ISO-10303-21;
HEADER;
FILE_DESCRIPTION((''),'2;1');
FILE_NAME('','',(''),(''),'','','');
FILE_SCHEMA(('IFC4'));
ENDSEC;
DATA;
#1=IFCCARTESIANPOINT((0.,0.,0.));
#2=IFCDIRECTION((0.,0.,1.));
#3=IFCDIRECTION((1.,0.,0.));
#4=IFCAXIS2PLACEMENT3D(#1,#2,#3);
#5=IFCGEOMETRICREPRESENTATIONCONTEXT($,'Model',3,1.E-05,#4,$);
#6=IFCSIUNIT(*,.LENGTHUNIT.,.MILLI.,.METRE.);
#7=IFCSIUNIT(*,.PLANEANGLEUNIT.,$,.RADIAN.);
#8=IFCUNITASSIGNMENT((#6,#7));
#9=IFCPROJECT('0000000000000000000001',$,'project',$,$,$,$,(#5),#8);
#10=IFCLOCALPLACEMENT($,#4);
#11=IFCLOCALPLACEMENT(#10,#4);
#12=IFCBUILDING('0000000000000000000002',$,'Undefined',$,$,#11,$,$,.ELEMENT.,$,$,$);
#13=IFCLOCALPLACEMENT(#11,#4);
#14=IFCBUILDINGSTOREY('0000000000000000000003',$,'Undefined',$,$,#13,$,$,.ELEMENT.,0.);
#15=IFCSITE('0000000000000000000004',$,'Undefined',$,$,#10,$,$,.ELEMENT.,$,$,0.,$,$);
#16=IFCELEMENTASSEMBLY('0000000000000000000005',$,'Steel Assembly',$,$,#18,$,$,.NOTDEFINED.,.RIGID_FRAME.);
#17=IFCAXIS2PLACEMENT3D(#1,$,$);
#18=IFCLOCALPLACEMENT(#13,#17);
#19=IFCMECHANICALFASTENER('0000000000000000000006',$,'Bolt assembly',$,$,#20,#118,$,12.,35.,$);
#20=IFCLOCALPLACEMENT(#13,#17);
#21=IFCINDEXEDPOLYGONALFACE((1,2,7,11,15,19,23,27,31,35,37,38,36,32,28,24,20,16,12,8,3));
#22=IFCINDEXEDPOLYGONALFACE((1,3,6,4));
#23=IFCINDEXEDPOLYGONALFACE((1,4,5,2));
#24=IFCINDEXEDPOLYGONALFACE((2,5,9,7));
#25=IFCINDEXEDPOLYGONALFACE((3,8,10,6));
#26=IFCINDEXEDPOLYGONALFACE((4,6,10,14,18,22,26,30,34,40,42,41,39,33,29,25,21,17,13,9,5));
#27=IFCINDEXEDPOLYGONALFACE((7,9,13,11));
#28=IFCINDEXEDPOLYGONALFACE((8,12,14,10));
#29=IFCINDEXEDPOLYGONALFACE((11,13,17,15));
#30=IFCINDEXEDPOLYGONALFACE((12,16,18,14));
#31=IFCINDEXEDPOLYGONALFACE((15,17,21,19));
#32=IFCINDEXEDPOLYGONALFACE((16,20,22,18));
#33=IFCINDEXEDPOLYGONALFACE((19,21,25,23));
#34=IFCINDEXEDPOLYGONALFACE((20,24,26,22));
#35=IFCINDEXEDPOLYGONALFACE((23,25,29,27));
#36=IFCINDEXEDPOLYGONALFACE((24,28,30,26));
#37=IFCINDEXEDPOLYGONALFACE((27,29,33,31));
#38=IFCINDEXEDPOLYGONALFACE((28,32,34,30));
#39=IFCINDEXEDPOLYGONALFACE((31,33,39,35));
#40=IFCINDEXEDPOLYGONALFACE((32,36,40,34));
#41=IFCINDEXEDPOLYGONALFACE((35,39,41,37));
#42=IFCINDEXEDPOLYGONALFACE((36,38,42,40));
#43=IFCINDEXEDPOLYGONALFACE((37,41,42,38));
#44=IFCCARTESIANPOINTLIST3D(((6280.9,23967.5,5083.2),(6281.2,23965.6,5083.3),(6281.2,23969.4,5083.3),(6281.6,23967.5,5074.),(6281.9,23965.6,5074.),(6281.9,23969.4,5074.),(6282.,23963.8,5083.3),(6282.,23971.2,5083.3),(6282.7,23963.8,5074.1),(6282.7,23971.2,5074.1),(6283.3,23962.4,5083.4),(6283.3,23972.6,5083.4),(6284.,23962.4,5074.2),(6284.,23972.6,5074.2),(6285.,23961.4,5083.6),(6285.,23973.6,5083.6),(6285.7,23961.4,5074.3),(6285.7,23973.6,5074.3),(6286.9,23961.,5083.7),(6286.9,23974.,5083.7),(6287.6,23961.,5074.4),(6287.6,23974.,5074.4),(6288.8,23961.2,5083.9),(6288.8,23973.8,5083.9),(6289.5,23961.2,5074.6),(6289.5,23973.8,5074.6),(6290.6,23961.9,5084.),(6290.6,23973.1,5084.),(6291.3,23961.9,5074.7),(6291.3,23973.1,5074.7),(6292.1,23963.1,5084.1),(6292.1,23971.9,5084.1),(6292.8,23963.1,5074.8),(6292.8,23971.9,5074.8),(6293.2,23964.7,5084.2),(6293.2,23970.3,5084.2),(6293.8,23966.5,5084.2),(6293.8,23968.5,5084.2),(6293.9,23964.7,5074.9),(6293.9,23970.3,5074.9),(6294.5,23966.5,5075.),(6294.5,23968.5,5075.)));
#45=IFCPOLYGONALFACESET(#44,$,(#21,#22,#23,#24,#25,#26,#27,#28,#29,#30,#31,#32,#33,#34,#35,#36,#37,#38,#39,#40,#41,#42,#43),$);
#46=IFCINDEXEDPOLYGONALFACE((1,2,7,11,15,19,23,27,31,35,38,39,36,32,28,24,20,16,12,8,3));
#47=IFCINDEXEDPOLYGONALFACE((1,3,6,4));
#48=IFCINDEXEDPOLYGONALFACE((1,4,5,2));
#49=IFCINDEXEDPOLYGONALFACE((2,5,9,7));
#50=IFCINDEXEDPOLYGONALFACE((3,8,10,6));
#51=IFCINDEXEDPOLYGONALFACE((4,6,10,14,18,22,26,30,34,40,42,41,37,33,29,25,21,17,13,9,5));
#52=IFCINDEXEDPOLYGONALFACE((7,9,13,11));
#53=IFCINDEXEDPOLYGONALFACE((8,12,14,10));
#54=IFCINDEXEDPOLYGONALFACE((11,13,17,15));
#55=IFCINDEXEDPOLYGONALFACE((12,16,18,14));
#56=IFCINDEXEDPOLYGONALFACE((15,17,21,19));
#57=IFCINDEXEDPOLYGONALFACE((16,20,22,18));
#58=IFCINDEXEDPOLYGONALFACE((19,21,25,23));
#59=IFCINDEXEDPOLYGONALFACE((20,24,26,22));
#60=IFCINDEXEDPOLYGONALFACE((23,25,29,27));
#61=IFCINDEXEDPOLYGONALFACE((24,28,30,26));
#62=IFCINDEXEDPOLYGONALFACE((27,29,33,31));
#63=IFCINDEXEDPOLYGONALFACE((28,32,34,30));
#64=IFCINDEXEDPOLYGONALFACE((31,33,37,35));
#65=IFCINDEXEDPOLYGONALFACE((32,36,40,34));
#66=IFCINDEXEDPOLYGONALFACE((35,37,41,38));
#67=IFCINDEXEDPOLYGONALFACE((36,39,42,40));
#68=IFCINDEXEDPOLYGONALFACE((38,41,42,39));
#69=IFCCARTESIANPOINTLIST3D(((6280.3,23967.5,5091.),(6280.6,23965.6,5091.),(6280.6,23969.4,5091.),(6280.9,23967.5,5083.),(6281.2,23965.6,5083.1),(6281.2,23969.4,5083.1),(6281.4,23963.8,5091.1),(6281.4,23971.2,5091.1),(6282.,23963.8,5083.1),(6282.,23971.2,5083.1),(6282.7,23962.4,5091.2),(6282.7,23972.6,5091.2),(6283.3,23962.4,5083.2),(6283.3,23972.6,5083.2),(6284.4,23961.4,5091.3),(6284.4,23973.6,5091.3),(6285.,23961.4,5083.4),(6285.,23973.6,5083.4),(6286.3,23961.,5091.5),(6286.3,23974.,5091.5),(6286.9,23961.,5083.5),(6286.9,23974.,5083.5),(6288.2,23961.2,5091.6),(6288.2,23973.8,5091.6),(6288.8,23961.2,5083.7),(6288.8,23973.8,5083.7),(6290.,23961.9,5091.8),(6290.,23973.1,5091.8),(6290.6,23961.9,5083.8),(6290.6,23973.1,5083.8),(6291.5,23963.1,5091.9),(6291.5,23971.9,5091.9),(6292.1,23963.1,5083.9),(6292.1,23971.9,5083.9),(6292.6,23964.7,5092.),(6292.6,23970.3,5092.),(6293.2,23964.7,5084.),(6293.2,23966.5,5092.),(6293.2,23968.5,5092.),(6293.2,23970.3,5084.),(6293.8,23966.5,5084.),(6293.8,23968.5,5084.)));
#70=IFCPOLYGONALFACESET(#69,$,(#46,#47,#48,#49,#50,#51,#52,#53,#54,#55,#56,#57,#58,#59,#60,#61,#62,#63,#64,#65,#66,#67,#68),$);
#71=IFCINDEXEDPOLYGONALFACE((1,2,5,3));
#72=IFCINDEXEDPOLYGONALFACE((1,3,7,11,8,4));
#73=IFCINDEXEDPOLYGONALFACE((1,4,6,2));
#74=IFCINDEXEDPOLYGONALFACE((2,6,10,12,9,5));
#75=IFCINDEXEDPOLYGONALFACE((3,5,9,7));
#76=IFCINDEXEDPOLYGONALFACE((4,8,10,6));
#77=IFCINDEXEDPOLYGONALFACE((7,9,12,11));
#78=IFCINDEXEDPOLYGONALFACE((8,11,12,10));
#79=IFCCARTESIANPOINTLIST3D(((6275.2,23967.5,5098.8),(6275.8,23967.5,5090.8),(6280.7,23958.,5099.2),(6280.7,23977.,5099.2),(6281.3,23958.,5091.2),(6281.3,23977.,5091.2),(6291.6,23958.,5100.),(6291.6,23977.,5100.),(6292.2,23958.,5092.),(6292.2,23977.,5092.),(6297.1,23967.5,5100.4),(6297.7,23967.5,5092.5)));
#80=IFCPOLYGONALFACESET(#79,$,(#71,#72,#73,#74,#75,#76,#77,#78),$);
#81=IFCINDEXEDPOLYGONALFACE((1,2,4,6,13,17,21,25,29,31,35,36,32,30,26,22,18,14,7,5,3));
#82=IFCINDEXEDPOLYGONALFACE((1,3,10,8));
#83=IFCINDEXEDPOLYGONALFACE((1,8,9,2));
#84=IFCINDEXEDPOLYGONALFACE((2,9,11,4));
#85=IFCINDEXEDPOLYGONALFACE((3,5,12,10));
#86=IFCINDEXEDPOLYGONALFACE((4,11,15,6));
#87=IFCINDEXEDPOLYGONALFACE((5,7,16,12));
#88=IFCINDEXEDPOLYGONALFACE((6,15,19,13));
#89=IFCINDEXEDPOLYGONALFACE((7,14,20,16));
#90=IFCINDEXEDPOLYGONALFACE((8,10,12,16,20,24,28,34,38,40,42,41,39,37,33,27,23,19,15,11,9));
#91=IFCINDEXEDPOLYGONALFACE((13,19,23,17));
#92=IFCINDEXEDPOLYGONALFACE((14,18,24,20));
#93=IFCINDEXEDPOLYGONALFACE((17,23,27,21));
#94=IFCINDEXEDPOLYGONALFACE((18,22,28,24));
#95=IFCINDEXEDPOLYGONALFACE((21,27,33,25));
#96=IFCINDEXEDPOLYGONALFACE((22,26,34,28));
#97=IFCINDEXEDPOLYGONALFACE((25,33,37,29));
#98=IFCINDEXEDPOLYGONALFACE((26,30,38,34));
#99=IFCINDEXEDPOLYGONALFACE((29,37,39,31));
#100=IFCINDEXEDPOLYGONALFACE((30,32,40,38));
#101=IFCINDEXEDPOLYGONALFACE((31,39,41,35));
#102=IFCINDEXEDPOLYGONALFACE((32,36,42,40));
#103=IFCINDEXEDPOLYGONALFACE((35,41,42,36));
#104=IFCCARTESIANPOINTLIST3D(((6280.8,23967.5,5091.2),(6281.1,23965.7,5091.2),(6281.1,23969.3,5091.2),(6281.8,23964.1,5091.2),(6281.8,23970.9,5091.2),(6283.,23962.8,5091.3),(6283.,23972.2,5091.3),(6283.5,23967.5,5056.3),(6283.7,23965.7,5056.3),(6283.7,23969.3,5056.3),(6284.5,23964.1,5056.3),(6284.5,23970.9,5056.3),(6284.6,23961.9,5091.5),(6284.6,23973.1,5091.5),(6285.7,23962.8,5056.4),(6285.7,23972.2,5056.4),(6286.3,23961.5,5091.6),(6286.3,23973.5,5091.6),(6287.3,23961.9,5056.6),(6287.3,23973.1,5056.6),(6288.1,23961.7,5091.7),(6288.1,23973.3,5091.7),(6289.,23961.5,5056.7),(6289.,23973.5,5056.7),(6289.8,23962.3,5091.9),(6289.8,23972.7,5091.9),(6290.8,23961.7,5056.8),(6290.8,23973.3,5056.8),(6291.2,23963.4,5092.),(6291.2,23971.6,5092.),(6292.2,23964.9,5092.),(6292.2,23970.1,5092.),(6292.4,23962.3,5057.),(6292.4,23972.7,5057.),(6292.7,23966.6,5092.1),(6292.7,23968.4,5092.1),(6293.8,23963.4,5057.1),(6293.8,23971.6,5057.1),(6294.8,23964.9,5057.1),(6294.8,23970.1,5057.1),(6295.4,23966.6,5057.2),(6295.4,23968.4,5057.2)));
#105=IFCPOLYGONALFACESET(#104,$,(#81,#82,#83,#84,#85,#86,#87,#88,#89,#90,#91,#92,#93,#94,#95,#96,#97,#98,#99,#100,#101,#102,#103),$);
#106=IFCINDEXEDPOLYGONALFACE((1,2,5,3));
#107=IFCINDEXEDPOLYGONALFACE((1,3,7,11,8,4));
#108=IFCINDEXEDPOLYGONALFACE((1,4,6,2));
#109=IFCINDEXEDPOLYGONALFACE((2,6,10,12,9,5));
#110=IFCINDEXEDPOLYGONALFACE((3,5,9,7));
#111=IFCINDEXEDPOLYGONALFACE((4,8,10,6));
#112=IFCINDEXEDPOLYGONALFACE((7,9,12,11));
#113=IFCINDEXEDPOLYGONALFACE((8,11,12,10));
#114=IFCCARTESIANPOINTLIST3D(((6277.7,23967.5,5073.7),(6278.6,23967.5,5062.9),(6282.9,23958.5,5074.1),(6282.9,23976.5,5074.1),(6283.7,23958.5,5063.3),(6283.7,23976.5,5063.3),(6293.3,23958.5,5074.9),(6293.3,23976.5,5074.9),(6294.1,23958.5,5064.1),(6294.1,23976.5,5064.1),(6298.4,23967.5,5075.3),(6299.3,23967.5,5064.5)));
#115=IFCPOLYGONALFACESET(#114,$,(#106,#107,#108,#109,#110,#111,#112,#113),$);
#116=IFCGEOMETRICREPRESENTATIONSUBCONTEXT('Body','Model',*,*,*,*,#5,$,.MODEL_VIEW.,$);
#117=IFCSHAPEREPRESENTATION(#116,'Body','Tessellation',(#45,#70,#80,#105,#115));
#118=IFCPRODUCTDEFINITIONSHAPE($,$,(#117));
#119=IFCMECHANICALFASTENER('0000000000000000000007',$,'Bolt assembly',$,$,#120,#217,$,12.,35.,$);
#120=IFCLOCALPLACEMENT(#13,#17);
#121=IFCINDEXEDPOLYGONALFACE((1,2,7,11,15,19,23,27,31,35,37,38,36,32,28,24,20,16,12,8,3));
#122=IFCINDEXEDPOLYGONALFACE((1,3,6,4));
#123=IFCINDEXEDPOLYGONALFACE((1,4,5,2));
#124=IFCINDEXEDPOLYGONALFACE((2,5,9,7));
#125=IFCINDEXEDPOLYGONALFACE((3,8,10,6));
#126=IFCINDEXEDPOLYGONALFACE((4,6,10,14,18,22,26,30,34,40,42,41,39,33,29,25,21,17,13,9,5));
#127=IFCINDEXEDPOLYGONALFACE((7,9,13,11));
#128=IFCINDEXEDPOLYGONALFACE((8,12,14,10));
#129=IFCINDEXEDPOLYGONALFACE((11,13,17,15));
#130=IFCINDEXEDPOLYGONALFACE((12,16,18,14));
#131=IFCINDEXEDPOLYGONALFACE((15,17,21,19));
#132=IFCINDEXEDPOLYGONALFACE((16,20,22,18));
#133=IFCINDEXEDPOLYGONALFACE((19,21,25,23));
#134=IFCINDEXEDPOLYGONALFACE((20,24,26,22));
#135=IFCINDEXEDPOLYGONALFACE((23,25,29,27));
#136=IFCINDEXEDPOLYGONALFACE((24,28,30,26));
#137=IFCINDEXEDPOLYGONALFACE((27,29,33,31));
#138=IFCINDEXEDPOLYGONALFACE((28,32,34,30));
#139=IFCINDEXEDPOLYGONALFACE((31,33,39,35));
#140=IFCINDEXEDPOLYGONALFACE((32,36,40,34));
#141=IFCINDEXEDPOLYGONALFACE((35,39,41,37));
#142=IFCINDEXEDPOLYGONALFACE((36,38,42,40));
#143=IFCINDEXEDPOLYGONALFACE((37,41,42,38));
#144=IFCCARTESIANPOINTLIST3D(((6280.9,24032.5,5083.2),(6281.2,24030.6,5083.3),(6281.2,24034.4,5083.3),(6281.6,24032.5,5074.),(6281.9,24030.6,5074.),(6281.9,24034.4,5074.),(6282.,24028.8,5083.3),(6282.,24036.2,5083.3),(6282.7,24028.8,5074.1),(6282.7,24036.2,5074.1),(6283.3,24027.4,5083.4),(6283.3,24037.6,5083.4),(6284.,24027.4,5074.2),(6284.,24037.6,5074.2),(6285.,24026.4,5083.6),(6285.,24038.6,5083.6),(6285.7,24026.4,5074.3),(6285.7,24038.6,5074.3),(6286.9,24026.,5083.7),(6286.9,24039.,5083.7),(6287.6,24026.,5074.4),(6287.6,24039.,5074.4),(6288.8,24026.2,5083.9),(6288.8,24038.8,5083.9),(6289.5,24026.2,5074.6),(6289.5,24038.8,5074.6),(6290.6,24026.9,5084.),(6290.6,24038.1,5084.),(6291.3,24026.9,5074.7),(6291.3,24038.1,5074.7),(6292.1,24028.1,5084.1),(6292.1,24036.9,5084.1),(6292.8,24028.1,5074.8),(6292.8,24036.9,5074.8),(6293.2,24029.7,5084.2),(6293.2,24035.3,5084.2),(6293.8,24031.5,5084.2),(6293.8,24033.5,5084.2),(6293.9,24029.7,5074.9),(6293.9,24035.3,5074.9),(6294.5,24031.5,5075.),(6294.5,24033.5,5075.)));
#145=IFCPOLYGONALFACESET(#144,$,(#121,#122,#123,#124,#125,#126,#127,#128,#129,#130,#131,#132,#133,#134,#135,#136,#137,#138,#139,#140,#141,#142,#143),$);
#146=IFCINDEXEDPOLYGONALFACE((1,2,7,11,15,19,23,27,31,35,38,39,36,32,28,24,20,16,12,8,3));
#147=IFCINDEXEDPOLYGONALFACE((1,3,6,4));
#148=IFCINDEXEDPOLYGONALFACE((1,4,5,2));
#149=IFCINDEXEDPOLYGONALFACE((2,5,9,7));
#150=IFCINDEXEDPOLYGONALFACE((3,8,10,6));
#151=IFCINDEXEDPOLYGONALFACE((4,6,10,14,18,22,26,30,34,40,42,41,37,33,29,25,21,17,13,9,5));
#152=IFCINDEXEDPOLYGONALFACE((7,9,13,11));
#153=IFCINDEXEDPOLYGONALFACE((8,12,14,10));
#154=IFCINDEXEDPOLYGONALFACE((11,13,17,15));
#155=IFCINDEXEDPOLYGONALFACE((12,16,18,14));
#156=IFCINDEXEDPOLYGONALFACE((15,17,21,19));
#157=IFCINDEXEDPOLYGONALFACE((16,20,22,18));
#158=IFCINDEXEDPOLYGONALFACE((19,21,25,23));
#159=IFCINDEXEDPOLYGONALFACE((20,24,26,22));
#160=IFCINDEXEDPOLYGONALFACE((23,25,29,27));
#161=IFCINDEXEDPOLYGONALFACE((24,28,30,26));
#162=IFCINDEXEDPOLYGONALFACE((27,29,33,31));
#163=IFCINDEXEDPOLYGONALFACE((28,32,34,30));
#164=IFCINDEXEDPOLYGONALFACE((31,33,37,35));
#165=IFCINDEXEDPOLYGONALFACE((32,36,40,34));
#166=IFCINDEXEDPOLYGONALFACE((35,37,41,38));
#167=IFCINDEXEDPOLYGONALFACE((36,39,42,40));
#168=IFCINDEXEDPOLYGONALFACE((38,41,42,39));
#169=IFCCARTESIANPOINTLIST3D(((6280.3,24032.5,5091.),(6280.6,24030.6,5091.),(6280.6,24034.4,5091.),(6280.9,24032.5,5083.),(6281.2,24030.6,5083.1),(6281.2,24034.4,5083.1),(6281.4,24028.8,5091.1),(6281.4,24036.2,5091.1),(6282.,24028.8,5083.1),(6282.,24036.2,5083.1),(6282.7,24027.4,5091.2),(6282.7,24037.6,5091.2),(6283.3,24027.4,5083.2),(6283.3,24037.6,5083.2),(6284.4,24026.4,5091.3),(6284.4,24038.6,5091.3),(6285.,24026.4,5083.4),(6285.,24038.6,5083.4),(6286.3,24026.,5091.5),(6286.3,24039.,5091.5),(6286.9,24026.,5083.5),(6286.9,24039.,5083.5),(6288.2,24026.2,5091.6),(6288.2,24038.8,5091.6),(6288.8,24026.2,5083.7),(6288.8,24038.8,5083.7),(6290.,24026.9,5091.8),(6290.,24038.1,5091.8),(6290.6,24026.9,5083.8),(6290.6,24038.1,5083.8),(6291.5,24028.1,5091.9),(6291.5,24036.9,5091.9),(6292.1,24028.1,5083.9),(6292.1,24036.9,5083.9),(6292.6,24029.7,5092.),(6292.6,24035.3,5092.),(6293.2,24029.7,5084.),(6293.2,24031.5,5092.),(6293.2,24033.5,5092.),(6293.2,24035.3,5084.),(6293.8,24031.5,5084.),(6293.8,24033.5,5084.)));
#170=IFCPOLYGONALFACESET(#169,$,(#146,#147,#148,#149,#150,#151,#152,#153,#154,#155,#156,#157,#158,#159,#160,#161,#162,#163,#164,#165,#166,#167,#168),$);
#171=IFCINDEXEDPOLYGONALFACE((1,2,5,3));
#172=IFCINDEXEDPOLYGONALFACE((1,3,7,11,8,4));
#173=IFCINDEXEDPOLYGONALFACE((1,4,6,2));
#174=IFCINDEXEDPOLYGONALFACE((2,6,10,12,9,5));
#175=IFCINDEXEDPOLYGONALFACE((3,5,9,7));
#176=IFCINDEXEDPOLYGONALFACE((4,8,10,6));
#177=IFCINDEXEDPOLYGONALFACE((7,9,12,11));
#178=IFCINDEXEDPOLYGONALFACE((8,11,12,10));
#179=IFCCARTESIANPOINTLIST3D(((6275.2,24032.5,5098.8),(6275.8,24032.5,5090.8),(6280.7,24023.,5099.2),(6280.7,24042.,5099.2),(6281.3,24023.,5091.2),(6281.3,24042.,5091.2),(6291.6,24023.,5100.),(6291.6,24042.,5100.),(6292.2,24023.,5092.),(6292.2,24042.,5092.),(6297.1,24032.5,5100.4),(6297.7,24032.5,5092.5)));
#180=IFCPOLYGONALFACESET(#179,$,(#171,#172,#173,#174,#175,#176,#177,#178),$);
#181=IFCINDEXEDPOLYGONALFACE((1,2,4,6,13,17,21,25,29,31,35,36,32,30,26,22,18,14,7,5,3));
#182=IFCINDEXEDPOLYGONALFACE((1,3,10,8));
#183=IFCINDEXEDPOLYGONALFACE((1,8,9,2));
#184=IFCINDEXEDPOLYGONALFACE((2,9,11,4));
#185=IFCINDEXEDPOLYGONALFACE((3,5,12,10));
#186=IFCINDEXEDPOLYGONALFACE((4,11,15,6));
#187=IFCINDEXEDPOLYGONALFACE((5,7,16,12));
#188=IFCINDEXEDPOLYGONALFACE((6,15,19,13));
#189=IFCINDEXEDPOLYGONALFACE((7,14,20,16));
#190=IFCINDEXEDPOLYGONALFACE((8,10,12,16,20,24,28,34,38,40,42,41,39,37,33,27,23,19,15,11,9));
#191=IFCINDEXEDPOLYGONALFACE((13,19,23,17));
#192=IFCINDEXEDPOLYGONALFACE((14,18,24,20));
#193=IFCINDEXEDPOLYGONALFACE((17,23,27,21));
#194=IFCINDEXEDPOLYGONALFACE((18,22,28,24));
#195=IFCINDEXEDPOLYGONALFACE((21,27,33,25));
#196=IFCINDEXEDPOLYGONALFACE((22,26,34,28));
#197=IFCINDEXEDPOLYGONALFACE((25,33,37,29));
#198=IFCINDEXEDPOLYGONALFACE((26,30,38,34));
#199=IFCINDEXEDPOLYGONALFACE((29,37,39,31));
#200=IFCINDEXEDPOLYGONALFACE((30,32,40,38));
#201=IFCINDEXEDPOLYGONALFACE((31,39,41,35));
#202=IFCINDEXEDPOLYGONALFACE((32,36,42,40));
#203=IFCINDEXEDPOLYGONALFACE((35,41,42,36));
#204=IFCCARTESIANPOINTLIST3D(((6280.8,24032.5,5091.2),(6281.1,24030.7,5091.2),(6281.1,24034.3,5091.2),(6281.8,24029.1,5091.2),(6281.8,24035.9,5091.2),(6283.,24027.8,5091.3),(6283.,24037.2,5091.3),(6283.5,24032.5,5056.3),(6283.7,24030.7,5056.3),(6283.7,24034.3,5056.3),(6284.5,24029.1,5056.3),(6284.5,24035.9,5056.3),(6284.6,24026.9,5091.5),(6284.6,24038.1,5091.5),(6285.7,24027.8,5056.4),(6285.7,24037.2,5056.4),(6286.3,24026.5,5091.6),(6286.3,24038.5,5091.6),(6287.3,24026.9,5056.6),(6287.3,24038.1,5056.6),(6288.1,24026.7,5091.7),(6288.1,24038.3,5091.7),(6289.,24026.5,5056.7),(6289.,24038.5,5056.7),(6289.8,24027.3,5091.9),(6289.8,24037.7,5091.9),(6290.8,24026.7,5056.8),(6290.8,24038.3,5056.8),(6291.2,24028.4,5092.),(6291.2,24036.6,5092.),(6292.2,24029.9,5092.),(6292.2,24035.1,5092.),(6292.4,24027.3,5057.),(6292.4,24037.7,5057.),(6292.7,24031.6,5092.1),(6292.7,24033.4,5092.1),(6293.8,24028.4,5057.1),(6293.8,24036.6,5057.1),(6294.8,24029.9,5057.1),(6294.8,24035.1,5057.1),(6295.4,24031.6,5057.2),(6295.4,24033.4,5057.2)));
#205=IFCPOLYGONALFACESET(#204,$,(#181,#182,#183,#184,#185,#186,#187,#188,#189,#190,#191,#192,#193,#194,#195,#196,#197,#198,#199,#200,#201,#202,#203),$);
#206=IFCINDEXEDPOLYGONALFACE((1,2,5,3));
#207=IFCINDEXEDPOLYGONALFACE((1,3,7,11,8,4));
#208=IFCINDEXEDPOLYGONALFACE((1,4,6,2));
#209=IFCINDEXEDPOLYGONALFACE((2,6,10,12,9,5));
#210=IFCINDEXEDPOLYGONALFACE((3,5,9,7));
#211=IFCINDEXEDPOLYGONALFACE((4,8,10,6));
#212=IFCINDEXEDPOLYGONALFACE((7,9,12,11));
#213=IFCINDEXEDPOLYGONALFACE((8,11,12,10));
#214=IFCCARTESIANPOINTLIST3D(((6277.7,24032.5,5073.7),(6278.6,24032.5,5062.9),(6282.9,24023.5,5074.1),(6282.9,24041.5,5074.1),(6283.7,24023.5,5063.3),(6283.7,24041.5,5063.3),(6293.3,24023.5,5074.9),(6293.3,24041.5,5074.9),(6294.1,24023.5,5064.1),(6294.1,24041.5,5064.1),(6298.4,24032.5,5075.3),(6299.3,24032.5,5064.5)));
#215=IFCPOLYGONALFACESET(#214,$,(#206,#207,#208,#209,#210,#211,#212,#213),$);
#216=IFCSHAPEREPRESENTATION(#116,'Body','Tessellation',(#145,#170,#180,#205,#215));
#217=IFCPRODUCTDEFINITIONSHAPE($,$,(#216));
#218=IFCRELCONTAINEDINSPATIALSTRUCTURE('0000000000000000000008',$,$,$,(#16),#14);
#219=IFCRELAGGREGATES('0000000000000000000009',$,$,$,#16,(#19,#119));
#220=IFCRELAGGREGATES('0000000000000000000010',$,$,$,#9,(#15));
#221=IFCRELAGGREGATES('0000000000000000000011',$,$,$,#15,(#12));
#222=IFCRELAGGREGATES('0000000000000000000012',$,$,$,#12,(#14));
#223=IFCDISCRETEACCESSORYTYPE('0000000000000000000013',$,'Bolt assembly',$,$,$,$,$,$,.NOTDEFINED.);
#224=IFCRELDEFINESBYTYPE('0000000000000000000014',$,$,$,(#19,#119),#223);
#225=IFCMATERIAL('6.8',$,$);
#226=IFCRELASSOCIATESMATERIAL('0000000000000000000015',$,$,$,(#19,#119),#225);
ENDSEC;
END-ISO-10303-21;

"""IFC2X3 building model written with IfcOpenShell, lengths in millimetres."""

from ifc_helpers import new_model, si_unit, frame, origin_with_axes, origin_2d_with_axis, place, context, subcontext, project, spatial, polyline, circle, outline, extrude, source, transform, mapped, material, type_object, element, aggregate, save


model = new_model("IFC2X3")

# Units and contexts
model_context = context("Model", 3, precision=1e-05, world=origin_with_axes())
body_context = subcontext(model_context, "Body", "Model", "MODEL_VIEW")
ifc_project = project(units=[si_unit("LENGTHUNIT", "METRE", prefix="MILLI"), si_unit("PLANEANGLEUNIT", "RADIAN")], contexts=[model_context])

# Site, building, storey
site_placement = place(None, origin_with_axes())
site = spatial("IfcSite", under=ifc_project, at=site_placement, Name="Undefined", CompositionType="ELEMENT", RefElevation=0.0)
building_placement = place(site_placement, origin_with_axes())
building = spatial("IfcBuilding", under=site, at=building_placement, Name="Undefined", CompositionType="ELEMENT")
storey_placement = place(building_placement, origin_with_axes())
storey = spatial("IfcBuildingStorey", under=building, at=storey_placement, Name="Undefined", CompositionType="ELEMENT", Elevation=0.0)

# Shared definitions
ifc_material_1 = material(Name="6.8")
discrete_accessory_type_1 = type_object("IfcDiscreteAccessoryType", Name="Bolt assembly")

# Element assembly, mechanical fasteners
assembly_1_placement = place(storey_placement, origin_with_axes())
assembly_1 = element("IfcElementAssembly", 1, at=assembly_1_placement, inside=storey, Name="Steel Assembly", AssemblyPlace="NOTDEFINED", PredefinedType="RIGID_FRAME")
shared_shape_1 = source(origin_with_axes(), body_context, "Body", "SweptSolid", [
    extrude(circle(Radius=6.5, at=origin_2d_with_axis()), frame((0.0, -0.1, 0.0), z_axis=(0.0, 1.0, 0.0), x_axis=(1.0, 0.0, 0.0)), (0.0, 0.0, 1.0), 9.3),
    extrude(circle(Radius=6.5, at=origin_2d_with_axis()), frame((0.0, -7.9, 0.0), z_axis=(0.0, 1.0, 0.0), x_axis=(1.0, 0.0, 0.0)), (0.0, 0.0, 1.0), 8.0),
    extrude(outline(polyline([(11.0, 0.0), (5.5, 9.5), (-5.5, 9.5), (-11.0, 0.0), (-5.5, -9.5), (5.5, -9.5), (11.0, 0.0)])), frame((0.0, -16.0, 0.0), z_axis=(0.0, 1.0, 0.0), x_axis=(1.0, 0.0, 0.0)), (0.0, 0.0, 1.0), 8.0),
    extrude(circle(Radius=6.0, at=origin_2d_with_axis()), frame((0.0, -8.0, 0.0), z_axis=(0.0, 1.0, 0.0), x_axis=(1.0, 0.0, 0.0)), (0.0, 0.0, 1.0), 35.0),
    extrude(outline(polyline([(10.4, 0.0), (5.2, 9.0), (-5.2, 9.0), (-10.4, 0.0), (-5.2, -9.0), (5.2, -9.0), (10.4, 0.0)])), frame((0.0, 9.2, 0.0), z_axis=(0.0, 1.0, 0.0), x_axis=(1.0, 0.0, 0.0)), (0.0, 0.0, 1.0), 10.8),
])
mechanical_fastener_1_placement = place(assembly_1_placement, frame((6287.4, 23967.5, 5083.6), z_axis=(0.0, -1.0, 0.0), x_axis=(-0.997054, 0.0, -0.076696)))
mechanical_fastener_1 = element("IfcMechanicalFastener", 2, at=mechanical_fastener_1_placement, type_object=discrete_accessory_type_1, material=ifc_material_1, Name="Bolt assembly", NominalDiameter=12.0, NominalLength=35.0, context=body_context, shape_type="MappedRepresentation", body=[
    mapped(shared_shape_1, transform((0.0, 0.0, 0.0))),
])
mechanical_fastener_2_placement = place(assembly_1_placement, frame((6287.4, 24032.5, 5083.6), z_axis=(0.0, -1.0, 0.0), x_axis=(-0.997054, 0.0, -0.076696)))
mechanical_fastener_2 = element("IfcMechanicalFastener", 3, at=mechanical_fastener_2_placement, type_object=discrete_accessory_type_1, material=ifc_material_1, Name="Bolt assembly", NominalDiameter=12.0, NominalLength=35.0, context=body_context, shape_type="MappedRepresentation", body=[
    mapped(shared_shape_1, transform((0.0, 0.0, 0.0))),
])
aggregate(assembly_1, [mechanical_fastener_1, mechanical_fastener_2])

save(model, "model.ifc")
